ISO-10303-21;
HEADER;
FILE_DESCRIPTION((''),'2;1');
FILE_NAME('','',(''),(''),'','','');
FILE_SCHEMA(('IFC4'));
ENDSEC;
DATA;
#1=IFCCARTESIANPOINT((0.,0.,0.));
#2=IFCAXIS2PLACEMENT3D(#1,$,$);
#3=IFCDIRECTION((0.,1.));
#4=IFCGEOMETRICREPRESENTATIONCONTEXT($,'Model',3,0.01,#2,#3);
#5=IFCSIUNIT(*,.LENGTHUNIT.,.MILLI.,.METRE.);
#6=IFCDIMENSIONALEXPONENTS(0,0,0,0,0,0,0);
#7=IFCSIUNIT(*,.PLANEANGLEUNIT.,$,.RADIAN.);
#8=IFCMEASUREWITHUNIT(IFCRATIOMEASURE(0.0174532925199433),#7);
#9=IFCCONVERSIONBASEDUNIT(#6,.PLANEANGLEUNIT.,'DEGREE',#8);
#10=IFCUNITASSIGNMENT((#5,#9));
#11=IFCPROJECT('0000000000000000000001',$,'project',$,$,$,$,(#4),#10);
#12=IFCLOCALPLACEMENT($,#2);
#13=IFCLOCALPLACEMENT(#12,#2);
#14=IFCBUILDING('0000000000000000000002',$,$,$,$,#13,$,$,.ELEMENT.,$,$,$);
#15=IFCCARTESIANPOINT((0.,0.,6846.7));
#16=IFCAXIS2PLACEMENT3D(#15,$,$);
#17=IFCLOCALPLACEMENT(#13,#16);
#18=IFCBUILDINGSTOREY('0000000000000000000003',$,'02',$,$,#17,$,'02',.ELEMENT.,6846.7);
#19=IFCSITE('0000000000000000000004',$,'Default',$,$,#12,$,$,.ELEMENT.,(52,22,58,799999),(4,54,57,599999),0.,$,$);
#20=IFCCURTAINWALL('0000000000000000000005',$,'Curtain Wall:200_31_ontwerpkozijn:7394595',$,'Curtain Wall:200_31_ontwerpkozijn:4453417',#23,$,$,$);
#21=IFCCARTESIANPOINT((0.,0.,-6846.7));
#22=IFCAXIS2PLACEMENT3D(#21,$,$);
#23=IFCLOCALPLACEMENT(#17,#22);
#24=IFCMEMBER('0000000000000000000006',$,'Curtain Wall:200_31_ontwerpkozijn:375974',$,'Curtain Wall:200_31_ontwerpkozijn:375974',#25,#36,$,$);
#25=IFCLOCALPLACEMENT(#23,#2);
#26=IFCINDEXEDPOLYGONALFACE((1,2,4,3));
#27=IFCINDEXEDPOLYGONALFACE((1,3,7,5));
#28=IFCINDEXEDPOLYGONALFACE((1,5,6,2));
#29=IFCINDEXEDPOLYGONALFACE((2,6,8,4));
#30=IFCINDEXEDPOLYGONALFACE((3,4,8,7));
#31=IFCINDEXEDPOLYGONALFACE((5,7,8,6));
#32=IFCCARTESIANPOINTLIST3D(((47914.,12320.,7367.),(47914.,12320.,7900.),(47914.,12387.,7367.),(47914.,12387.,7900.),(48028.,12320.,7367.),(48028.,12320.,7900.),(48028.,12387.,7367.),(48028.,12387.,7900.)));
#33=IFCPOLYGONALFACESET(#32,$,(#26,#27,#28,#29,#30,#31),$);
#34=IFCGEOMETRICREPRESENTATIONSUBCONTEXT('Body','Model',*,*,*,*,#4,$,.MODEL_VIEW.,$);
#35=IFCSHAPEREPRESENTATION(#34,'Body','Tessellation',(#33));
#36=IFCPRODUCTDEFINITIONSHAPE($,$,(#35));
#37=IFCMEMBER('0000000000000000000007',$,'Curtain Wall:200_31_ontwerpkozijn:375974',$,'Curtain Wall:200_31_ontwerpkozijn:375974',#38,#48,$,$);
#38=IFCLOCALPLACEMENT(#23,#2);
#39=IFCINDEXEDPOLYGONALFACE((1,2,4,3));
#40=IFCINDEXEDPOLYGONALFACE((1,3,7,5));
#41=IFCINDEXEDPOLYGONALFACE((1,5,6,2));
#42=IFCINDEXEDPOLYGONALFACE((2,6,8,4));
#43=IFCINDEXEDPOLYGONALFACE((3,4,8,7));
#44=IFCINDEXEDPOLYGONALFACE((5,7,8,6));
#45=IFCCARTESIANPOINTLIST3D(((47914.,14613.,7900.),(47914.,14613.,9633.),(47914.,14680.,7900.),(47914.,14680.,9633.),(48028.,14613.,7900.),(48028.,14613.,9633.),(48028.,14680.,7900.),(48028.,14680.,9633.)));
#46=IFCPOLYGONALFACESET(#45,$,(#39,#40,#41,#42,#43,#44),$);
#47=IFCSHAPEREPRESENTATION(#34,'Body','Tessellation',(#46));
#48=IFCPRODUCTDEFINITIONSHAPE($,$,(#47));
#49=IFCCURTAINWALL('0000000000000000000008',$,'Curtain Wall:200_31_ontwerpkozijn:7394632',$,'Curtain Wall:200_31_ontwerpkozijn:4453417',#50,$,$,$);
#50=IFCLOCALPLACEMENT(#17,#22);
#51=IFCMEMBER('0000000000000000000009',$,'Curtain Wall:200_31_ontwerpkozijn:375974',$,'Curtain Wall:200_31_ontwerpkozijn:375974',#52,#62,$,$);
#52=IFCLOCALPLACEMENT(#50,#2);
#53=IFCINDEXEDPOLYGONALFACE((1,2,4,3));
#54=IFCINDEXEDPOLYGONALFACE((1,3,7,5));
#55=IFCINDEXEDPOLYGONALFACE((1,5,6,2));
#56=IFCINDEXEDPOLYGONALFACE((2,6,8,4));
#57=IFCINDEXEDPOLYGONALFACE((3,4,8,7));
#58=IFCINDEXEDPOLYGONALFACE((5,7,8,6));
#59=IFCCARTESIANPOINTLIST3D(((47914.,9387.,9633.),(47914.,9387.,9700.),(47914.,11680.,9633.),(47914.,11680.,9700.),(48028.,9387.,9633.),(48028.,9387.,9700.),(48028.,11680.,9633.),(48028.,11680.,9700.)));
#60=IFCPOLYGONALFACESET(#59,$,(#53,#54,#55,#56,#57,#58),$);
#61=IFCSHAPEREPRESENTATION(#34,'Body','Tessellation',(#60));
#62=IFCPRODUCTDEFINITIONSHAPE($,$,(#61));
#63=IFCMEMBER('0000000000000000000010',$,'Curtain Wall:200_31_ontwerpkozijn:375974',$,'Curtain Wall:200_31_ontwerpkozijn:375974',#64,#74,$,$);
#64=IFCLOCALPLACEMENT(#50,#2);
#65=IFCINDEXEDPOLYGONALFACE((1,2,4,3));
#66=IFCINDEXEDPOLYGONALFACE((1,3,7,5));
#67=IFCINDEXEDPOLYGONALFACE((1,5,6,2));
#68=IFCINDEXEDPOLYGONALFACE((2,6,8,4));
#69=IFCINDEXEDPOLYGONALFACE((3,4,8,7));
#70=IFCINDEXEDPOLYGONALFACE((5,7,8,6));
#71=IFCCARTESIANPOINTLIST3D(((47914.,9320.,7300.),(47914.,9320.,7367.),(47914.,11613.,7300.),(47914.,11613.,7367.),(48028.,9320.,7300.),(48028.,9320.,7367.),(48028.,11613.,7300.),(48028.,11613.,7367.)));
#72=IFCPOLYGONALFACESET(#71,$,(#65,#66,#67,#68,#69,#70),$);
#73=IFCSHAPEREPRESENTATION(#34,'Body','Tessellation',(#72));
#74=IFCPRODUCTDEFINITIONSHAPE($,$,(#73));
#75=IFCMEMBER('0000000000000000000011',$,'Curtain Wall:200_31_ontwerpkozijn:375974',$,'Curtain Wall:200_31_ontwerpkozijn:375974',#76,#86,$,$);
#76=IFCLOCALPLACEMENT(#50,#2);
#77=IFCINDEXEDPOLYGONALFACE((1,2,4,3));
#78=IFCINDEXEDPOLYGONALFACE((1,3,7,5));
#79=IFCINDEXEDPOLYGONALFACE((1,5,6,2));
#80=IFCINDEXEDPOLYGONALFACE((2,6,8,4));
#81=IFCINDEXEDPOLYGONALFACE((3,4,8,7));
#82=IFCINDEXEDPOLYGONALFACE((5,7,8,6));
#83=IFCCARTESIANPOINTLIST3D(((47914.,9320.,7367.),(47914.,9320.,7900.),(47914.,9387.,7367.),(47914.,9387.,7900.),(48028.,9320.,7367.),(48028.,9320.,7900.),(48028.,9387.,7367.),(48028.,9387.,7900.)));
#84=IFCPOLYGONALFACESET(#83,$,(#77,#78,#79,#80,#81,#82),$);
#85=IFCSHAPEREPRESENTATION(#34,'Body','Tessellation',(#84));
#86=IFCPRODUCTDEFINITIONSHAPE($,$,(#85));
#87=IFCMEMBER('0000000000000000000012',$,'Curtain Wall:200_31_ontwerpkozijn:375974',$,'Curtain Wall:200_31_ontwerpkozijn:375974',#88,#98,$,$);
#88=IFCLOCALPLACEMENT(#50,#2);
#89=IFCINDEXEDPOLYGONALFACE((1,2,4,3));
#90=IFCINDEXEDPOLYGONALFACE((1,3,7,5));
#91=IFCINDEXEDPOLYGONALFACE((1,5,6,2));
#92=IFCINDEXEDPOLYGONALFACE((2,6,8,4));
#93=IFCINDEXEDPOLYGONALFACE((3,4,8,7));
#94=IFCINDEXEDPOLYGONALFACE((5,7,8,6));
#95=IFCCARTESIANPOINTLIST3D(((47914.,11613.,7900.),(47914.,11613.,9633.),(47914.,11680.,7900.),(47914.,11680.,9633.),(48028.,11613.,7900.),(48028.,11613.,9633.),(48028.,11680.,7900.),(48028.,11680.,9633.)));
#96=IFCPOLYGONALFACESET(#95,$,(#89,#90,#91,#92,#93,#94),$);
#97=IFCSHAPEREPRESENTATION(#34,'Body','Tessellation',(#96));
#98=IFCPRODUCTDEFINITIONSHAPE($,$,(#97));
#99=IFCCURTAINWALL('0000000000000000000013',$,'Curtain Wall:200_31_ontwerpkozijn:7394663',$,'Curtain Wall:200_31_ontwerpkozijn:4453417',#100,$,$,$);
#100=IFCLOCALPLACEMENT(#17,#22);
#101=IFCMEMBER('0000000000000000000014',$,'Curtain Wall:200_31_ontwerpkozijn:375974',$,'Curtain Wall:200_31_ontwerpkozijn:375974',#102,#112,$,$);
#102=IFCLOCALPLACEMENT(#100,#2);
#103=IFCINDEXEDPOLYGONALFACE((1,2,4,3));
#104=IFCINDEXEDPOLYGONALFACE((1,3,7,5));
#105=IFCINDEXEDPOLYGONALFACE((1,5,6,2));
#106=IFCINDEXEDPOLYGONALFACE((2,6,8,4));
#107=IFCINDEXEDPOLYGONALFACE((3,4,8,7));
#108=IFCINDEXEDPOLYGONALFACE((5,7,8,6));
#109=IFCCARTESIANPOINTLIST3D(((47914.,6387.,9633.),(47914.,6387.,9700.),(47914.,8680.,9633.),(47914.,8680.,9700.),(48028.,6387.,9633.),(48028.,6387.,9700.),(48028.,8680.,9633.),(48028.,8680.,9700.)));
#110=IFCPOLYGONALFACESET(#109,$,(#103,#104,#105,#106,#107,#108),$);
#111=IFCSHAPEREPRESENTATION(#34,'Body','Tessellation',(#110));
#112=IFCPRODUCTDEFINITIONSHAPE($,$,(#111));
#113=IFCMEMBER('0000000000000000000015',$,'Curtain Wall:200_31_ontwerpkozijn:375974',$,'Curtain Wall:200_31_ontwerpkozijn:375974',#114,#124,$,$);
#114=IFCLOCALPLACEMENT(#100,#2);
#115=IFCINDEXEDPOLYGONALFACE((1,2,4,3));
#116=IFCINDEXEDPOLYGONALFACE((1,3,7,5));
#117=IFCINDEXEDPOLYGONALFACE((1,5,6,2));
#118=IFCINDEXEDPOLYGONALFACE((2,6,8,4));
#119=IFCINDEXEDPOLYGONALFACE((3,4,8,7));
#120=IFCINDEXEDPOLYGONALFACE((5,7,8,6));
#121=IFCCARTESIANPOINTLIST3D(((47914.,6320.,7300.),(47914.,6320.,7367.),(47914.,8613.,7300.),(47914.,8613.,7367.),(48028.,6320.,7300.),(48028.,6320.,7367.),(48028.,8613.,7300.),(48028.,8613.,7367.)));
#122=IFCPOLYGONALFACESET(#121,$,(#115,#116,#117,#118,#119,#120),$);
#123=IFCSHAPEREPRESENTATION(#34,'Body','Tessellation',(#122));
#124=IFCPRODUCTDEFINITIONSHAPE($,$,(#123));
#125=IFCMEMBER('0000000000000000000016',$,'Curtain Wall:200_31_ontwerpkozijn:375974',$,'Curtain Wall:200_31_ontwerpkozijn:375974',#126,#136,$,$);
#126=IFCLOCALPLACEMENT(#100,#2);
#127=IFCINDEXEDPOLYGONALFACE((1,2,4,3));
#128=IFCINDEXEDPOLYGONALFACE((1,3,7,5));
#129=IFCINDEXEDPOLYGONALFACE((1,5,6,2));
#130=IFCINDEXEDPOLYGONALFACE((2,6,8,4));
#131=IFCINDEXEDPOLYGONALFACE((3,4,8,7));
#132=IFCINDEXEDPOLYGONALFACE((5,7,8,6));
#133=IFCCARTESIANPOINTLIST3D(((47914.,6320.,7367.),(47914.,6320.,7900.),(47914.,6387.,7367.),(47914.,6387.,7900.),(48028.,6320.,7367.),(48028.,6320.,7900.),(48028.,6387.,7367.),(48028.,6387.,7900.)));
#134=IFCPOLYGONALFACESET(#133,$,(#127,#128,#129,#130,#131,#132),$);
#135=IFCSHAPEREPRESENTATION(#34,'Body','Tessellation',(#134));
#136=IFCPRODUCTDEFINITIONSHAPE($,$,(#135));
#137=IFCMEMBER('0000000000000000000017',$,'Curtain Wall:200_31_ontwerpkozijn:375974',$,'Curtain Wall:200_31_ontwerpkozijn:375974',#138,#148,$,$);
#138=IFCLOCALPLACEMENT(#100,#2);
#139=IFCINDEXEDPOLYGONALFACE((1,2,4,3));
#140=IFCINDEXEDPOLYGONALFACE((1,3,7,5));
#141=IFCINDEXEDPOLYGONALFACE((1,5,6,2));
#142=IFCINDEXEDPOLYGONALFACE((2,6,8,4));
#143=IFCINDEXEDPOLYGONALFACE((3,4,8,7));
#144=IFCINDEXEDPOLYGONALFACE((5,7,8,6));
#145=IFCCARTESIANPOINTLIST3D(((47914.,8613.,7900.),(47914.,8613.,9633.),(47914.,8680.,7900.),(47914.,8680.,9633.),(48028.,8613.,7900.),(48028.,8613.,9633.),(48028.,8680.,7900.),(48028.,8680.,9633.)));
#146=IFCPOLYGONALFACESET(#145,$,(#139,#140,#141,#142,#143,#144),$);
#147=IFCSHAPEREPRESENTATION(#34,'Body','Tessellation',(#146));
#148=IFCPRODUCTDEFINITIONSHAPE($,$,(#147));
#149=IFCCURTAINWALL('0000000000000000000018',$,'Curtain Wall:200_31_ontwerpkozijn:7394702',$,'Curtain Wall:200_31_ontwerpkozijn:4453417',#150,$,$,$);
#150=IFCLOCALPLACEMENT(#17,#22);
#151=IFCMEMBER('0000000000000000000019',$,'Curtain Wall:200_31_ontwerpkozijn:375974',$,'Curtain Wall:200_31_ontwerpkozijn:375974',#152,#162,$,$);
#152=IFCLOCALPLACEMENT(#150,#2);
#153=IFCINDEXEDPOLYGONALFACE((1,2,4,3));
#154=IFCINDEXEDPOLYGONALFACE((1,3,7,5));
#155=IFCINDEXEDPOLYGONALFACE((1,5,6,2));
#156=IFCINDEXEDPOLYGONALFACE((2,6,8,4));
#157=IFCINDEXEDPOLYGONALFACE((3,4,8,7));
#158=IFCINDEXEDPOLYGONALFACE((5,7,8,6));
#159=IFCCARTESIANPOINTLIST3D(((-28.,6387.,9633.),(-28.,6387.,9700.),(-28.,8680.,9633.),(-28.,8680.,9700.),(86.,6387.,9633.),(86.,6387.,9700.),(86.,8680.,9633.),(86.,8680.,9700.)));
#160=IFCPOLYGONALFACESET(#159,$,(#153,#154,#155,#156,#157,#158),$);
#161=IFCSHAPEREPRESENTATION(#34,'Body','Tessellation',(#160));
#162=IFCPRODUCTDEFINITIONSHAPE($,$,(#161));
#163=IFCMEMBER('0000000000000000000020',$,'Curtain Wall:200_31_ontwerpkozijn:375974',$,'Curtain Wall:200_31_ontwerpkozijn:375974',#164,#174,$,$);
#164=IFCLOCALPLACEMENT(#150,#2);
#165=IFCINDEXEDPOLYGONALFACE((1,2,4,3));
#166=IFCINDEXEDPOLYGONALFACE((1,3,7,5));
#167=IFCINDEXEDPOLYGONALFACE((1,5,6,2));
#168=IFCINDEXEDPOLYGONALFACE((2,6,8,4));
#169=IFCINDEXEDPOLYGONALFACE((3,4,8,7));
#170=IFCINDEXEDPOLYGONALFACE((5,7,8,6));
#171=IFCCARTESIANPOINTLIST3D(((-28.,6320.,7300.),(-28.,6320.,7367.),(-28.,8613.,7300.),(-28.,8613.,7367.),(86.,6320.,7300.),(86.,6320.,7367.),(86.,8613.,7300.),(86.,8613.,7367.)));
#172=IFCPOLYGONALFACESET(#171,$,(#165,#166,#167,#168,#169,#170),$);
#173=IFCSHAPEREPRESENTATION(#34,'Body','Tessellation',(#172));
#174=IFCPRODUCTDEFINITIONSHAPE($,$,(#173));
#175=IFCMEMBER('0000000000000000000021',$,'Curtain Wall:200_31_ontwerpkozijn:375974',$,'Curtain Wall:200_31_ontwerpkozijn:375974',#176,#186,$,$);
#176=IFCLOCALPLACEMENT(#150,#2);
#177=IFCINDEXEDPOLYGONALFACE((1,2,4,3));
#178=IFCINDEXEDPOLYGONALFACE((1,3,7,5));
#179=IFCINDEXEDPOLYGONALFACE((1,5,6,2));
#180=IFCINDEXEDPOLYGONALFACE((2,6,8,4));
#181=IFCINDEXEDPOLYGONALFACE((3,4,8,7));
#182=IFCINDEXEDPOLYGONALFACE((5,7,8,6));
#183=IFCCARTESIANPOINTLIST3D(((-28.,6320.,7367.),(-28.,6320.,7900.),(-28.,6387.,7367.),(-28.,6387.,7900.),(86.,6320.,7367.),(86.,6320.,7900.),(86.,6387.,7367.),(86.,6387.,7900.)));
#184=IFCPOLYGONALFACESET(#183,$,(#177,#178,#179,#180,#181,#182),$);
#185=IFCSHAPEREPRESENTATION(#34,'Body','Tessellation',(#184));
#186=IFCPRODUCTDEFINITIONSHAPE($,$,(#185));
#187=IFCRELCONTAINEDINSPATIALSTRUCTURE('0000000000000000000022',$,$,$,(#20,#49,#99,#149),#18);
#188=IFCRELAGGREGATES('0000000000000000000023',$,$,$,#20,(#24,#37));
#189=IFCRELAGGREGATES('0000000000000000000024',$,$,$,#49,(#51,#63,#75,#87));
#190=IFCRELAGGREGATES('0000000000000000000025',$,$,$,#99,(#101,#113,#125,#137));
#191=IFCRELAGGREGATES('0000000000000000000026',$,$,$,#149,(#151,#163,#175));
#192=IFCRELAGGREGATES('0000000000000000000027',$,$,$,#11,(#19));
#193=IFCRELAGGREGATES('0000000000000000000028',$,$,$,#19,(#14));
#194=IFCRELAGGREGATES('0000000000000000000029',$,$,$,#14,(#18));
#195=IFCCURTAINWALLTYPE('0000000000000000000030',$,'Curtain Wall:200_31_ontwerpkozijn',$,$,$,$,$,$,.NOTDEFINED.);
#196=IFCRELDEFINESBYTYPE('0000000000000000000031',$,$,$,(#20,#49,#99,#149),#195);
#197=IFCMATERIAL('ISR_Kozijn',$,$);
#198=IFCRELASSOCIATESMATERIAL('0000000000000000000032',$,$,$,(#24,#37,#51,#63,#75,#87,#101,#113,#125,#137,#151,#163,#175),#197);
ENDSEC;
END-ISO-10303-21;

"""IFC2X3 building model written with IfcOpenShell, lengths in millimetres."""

from ifc_helpers import new_model, entity, si_unit, converted_unit, direction, frame, frame_2d, origin, origin_2d_with_axis, place, context, subcontext, project, spatial, rectangle, extrude, material, type_object, element, aggregate, save


model = new_model("IFC2X3")

# Units and contexts
model_context = context("Model", 3, precision=0.01, world=origin(), true_north=direction((0.0, 1.0)))
body_context = subcontext(model_context, "Body", "Model", "MODEL_VIEW")
ifc_project = project(units=[si_unit("LENGTHUNIT", "METRE", prefix="MILLI"), converted_unit("PLANEANGLEUNIT", "DEGREE", entity("IfcRatioMeasure", 0.0174532925199433), si_unit("PLANEANGLEUNIT", "RADIAN"), dimensions=[0, 0, 0, 0, 0, 0, 0])], contexts=[model_context])

# Site, building, storey
site_placement = place(None, origin())
site = spatial("IfcSite", under=ifc_project, at=site_placement, Name="Default", CompositionType="ELEMENT", RefLatitude=(52, 22, 58, 799999), RefLongitude=(4, 54, 57, 599999), RefElevation=0.0)
building_placement = place(site_placement, origin())
building = spatial("IfcBuilding", under=site, at=building_placement, CompositionType="ELEMENT")
storey_placement = place(building_placement, frame((0.0, 0.0, 6846.7)))
storey = spatial("IfcBuildingStorey", under=building, at=storey_placement, Name="02", LongName="02", CompositionType="ELEMENT", Elevation=6846.7)

# Curtain walls, members
curtain_wall_type = type_object("IfcCurtainWallType", Name="Curtain Wall:200_31_ontwerpkozijn", PredefinedType="NOTDEFINED")
ifc_material = material(Name="ISR_Kozijn")
curtain_wall_1_placement = place(storey_placement, frame((0.0, 0.0, -6846.7)))
curtain_wall_1 = element("IfcCurtainWall", 1, at=curtain_wall_1_placement, inside=storey, type_object=curtain_wall_type, Name="Curtain Wall:200_31_ontwerpkozijn:7394595", ObjectType="Curtain Wall:200_31_ontwerpkozijn:4453417")
member_1_placement = place(curtain_wall_1_placement, origin())
member_1 = element("IfcMember", 2, at=member_1_placement, material=ifc_material, Name="Curtain Wall:200_31_ontwerpkozijn:375974", ObjectType="Curtain Wall:200_31_ontwerpkozijn:375974", context=body_context, shape_type="SweptSolid", body=[
    extrude(rectangle(XDim=114.0, YDim=67.0, at=frame_2d((0.0, 0.0), x_axis=(1.0, 0.0))), frame((47971.0, 12353.5, 7367.0), z_axis=(0.0, 0.0, 1.0), x_axis=(-1.0, 0.0, 0.0)), (0.0, 0.0, 1.0), 533.0),
])
member_2_placement = place(curtain_wall_1_placement, origin())
member_2 = element("IfcMember", 3, at=member_2_placement, material=ifc_material, Name="Curtain Wall:200_31_ontwerpkozijn:375974", ObjectType="Curtain Wall:200_31_ontwerpkozijn:375974", context=body_context, shape_type="SweptSolid", body=[
    extrude(rectangle(XDim=114.0, YDim=67.0, at=frame_2d((0.0, 0.0), x_axis=(1.0, 0.0))), frame((47971.0, 14646.5, 9633.0), z_axis=(0.0, 0.0, -1.0), x_axis=(-1.0, 0.0, 0.0)), (0.0, 0.0, 1.0), 1733.0),
])
aggregate(curtain_wall_1, [member_1, member_2])
curtain_wall_2_placement = place(storey_placement, frame((0.0, 0.0, -6846.7)))
curtain_wall_2 = element("IfcCurtainWall", 4, at=curtain_wall_2_placement, inside=storey, type_object=curtain_wall_type, Name="Curtain Wall:200_31_ontwerpkozijn:7394632", ObjectType="Curtain Wall:200_31_ontwerpkozijn:4453417")
member_3_placement = place(curtain_wall_2_placement, origin())
member_3 = element("IfcMember", 5, at=member_3_placement, material=ifc_material, Name="Curtain Wall:200_31_ontwerpkozijn:375974", ObjectType="Curtain Wall:200_31_ontwerpkozijn:375974", context=body_context, shape_type="SweptSolid", body=[
    extrude(rectangle(XDim=67.0, YDim=114.0, at=frame_2d((0.0, 0.0), x_axis=(1.0, 0.0))), frame((47971.0, 9387.0, 9666.5), z_axis=(0.0, 1.0, 0.0), x_axis=(0.0, 0.0, -1.0)), (0.0, 0.0, 1.0), 2293.0),
])
member_4_placement = place(curtain_wall_2_placement, origin())
member_4 = element("IfcMember", 6, at=member_4_placement, material=ifc_material, Name="Curtain Wall:200_31_ontwerpkozijn:375974", ObjectType="Curtain Wall:200_31_ontwerpkozijn:375974", context=body_context, shape_type="SweptSolid", body=[
    extrude(rectangle(XDim=67.0, YDim=114.0, at=frame_2d((0.0, 0.0), x_axis=(1.0, 0.0))), frame((47971.0, 11613.0, 7333.5), z_axis=(0.0, -1.0, 0.0), x_axis=(0.0, 0.0, -1.0)), (0.0, 0.0, 1.0), 2293.0),
])
member_5_placement = place(curtain_wall_2_placement, origin())
member_5 = element("IfcMember", 7, at=member_5_placement, material=ifc_material, Name="Curtain Wall:200_31_ontwerpkozijn:375974", ObjectType="Curtain Wall:200_31_ontwerpkozijn:375974", context=body_context, shape_type="SweptSolid", body=[
    extrude(rectangle(XDim=114.0, YDim=67.0, at=frame_2d((0.0, 0.0), x_axis=(1.0, 0.0))), frame((47971.0, 9353.5, 7367.0), z_axis=(0.0, 0.0, 1.0), x_axis=(-1.0, 0.0, 0.0)), (0.0, 0.0, 1.0), 533.0),
])
member_6_placement = place(curtain_wall_2_placement, origin())
member_6 = element("IfcMember", 8, at=member_6_placement, material=ifc_material, Name="Curtain Wall:200_31_ontwerpkozijn:375974", ObjectType="Curtain Wall:200_31_ontwerpkozijn:375974", context=body_context, shape_type="SweptSolid", body=[
    extrude(rectangle(XDim=114.0, YDim=67.0, at=frame_2d((0.0, 0.0), x_axis=(1.0, 0.0))), frame((47971.0, 11646.5, 9633.0), z_axis=(0.0, 0.0, -1.0), x_axis=(-1.0, 0.0, 0.0)), (0.0, 0.0, 1.0), 1733.0),
])
aggregate(curtain_wall_2, [member_3, member_4, member_5, member_6])
curtain_wall_3_placement = place(storey_placement, frame((0.0, 0.0, -6846.7)))
curtain_wall_3 = element("IfcCurtainWall", 9, at=curtain_wall_3_placement, inside=storey, type_object=curtain_wall_type, Name="Curtain Wall:200_31_ontwerpkozijn:7394663", ObjectType="Curtain Wall:200_31_ontwerpkozijn:4453417")
member_7_placement = place(curtain_wall_3_placement, origin())
member_7 = element("IfcMember", 10, at=member_7_placement, material=ifc_material, Name="Curtain Wall:200_31_ontwerpkozijn:375974", ObjectType="Curtain Wall:200_31_ontwerpkozijn:375974", context=body_context, shape_type="SweptSolid", body=[
    extrude(rectangle(XDim=67.0, YDim=114.0, at=frame_2d((0.0, 0.0), x_axis=(1.0, 0.0))), frame((47971.0, 6387.0, 9666.5), z_axis=(0.0, 1.0, 0.0), x_axis=(0.0, 0.0, -1.0)), (0.0, 0.0, 1.0), 2293.0),
])
member_8_placement = place(curtain_wall_3_placement, origin())
member_8 = element("IfcMember", 11, at=member_8_placement, material=ifc_material, Name="Curtain Wall:200_31_ontwerpkozijn:375974", ObjectType="Curtain Wall:200_31_ontwerpkozijn:375974", context=body_context, shape_type="SweptSolid", body=[
    extrude(rectangle(XDim=67.0, YDim=114.0, at=frame_2d((0.0, 0.0), x_axis=(1.0, 0.0))), frame((47971.0, 8613.0, 7333.5), z_axis=(0.0, -1.0, 0.0), x_axis=(0.0, 0.0, -1.0)), (0.0, 0.0, 1.0), 2293.0),
])
member_9_placement = place(curtain_wall_3_placement, origin())
member_9 = element("IfcMember", 12, at=member_9_placement, material=ifc_material, Name="Curtain Wall:200_31_ontwerpkozijn:375974", ObjectType="Curtain Wall:200_31_ontwerpkozijn:375974", context=body_context, shape_type="SweptSolid", body=[
    extrude(rectangle(XDim=114.0, YDim=67.0, at=frame_2d((0.0, 0.0), x_axis=(1.0, 0.0))), frame((47971.0, 6353.5, 7367.0), z_axis=(0.0, 0.0, 1.0), x_axis=(-1.0, 0.0, 0.0)), (0.0, 0.0, 1.0), 533.0),
])
member_10_placement = place(curtain_wall_3_placement, origin())
member_10 = element("IfcMember", 13, at=member_10_placement, material=ifc_material, Name="Curtain Wall:200_31_ontwerpkozijn:375974", ObjectType="Curtain Wall:200_31_ontwerpkozijn:375974", context=body_context, shape_type="SweptSolid", body=[
    extrude(rectangle(XDim=114.0, YDim=67.0, at=frame_2d((0.0, 0.0), x_axis=(1.0, 0.0))), frame((47971.0, 8646.5, 9633.0), z_axis=(0.0, 0.0, -1.0), x_axis=(-1.0, 0.0, 0.0)), (0.0, 0.0, 1.0), 1733.0),
])
aggregate(curtain_wall_3, [member_7, member_8, member_9, member_10])
curtain_wall_4_placement = place(storey_placement, frame((0.0, 0.0, -6846.7)))
curtain_wall_4 = element("IfcCurtainWall", 14, at=curtain_wall_4_placement, inside=storey, type_object=curtain_wall_type, Name="Curtain Wall:200_31_ontwerpkozijn:7394702", ObjectType="Curtain Wall:200_31_ontwerpkozijn:4453417")
member_11_placement = place(curtain_wall_4_placement, origin())
member_11 = element("IfcMember", 15, at=member_11_placement, material=ifc_material, Name="Curtain Wall:200_31_ontwerpkozijn:375974", ObjectType="Curtain Wall:200_31_ontwerpkozijn:375974", context=body_context, shape_type="SweptSolid", body=[
    extrude(rectangle(XDim=67.0, YDim=114.0, at=origin_2d_with_axis()), frame((29.0, 6387.0, 9666.5), z_axis=(0.0, 1.0, 0.0), x_axis=(0.0, 0.0, -1.0)), (0.0, 0.0, 1.0), 2293.0),
])
member_12_placement = place(curtain_wall_4_placement, origin())
member_12 = element("IfcMember", 16, at=member_12_placement, material=ifc_material, Name="Curtain Wall:200_31_ontwerpkozijn:375974", ObjectType="Curtain Wall:200_31_ontwerpkozijn:375974", context=body_context, shape_type="SweptSolid", body=[
    extrude(rectangle(XDim=67.0, YDim=114.0, at=frame_2d((0.0, 0.0), x_axis=(1.0, 0.0))), frame((29.0, 8613.0, 7333.5), z_axis=(0.0, -1.0, 0.0), x_axis=(0.0, 0.0, -1.0)), (0.0, 0.0, 1.0), 2293.0),
])
member_13_placement = place(curtain_wall_4_placement, origin())
member_13 = element("IfcMember", 17, at=member_13_placement, material=ifc_material, Name="Curtain Wall:200_31_ontwerpkozijn:375974", ObjectType="Curtain Wall:200_31_ontwerpkozijn:375974", context=body_context, shape_type="SweptSolid", body=[
    extrude(rectangle(XDim=114.0, YDim=67.0, at=origin_2d_with_axis()), frame((29.0, 6353.5, 7367.0), z_axis=(0.0, 0.0, 1.0), x_axis=(-1.0, 0.0, 0.0)), (0.0, 0.0, 1.0), 533.0),
])
aggregate(curtain_wall_4, [member_11, member_12, member_13])

save(model, "model.ifc")
